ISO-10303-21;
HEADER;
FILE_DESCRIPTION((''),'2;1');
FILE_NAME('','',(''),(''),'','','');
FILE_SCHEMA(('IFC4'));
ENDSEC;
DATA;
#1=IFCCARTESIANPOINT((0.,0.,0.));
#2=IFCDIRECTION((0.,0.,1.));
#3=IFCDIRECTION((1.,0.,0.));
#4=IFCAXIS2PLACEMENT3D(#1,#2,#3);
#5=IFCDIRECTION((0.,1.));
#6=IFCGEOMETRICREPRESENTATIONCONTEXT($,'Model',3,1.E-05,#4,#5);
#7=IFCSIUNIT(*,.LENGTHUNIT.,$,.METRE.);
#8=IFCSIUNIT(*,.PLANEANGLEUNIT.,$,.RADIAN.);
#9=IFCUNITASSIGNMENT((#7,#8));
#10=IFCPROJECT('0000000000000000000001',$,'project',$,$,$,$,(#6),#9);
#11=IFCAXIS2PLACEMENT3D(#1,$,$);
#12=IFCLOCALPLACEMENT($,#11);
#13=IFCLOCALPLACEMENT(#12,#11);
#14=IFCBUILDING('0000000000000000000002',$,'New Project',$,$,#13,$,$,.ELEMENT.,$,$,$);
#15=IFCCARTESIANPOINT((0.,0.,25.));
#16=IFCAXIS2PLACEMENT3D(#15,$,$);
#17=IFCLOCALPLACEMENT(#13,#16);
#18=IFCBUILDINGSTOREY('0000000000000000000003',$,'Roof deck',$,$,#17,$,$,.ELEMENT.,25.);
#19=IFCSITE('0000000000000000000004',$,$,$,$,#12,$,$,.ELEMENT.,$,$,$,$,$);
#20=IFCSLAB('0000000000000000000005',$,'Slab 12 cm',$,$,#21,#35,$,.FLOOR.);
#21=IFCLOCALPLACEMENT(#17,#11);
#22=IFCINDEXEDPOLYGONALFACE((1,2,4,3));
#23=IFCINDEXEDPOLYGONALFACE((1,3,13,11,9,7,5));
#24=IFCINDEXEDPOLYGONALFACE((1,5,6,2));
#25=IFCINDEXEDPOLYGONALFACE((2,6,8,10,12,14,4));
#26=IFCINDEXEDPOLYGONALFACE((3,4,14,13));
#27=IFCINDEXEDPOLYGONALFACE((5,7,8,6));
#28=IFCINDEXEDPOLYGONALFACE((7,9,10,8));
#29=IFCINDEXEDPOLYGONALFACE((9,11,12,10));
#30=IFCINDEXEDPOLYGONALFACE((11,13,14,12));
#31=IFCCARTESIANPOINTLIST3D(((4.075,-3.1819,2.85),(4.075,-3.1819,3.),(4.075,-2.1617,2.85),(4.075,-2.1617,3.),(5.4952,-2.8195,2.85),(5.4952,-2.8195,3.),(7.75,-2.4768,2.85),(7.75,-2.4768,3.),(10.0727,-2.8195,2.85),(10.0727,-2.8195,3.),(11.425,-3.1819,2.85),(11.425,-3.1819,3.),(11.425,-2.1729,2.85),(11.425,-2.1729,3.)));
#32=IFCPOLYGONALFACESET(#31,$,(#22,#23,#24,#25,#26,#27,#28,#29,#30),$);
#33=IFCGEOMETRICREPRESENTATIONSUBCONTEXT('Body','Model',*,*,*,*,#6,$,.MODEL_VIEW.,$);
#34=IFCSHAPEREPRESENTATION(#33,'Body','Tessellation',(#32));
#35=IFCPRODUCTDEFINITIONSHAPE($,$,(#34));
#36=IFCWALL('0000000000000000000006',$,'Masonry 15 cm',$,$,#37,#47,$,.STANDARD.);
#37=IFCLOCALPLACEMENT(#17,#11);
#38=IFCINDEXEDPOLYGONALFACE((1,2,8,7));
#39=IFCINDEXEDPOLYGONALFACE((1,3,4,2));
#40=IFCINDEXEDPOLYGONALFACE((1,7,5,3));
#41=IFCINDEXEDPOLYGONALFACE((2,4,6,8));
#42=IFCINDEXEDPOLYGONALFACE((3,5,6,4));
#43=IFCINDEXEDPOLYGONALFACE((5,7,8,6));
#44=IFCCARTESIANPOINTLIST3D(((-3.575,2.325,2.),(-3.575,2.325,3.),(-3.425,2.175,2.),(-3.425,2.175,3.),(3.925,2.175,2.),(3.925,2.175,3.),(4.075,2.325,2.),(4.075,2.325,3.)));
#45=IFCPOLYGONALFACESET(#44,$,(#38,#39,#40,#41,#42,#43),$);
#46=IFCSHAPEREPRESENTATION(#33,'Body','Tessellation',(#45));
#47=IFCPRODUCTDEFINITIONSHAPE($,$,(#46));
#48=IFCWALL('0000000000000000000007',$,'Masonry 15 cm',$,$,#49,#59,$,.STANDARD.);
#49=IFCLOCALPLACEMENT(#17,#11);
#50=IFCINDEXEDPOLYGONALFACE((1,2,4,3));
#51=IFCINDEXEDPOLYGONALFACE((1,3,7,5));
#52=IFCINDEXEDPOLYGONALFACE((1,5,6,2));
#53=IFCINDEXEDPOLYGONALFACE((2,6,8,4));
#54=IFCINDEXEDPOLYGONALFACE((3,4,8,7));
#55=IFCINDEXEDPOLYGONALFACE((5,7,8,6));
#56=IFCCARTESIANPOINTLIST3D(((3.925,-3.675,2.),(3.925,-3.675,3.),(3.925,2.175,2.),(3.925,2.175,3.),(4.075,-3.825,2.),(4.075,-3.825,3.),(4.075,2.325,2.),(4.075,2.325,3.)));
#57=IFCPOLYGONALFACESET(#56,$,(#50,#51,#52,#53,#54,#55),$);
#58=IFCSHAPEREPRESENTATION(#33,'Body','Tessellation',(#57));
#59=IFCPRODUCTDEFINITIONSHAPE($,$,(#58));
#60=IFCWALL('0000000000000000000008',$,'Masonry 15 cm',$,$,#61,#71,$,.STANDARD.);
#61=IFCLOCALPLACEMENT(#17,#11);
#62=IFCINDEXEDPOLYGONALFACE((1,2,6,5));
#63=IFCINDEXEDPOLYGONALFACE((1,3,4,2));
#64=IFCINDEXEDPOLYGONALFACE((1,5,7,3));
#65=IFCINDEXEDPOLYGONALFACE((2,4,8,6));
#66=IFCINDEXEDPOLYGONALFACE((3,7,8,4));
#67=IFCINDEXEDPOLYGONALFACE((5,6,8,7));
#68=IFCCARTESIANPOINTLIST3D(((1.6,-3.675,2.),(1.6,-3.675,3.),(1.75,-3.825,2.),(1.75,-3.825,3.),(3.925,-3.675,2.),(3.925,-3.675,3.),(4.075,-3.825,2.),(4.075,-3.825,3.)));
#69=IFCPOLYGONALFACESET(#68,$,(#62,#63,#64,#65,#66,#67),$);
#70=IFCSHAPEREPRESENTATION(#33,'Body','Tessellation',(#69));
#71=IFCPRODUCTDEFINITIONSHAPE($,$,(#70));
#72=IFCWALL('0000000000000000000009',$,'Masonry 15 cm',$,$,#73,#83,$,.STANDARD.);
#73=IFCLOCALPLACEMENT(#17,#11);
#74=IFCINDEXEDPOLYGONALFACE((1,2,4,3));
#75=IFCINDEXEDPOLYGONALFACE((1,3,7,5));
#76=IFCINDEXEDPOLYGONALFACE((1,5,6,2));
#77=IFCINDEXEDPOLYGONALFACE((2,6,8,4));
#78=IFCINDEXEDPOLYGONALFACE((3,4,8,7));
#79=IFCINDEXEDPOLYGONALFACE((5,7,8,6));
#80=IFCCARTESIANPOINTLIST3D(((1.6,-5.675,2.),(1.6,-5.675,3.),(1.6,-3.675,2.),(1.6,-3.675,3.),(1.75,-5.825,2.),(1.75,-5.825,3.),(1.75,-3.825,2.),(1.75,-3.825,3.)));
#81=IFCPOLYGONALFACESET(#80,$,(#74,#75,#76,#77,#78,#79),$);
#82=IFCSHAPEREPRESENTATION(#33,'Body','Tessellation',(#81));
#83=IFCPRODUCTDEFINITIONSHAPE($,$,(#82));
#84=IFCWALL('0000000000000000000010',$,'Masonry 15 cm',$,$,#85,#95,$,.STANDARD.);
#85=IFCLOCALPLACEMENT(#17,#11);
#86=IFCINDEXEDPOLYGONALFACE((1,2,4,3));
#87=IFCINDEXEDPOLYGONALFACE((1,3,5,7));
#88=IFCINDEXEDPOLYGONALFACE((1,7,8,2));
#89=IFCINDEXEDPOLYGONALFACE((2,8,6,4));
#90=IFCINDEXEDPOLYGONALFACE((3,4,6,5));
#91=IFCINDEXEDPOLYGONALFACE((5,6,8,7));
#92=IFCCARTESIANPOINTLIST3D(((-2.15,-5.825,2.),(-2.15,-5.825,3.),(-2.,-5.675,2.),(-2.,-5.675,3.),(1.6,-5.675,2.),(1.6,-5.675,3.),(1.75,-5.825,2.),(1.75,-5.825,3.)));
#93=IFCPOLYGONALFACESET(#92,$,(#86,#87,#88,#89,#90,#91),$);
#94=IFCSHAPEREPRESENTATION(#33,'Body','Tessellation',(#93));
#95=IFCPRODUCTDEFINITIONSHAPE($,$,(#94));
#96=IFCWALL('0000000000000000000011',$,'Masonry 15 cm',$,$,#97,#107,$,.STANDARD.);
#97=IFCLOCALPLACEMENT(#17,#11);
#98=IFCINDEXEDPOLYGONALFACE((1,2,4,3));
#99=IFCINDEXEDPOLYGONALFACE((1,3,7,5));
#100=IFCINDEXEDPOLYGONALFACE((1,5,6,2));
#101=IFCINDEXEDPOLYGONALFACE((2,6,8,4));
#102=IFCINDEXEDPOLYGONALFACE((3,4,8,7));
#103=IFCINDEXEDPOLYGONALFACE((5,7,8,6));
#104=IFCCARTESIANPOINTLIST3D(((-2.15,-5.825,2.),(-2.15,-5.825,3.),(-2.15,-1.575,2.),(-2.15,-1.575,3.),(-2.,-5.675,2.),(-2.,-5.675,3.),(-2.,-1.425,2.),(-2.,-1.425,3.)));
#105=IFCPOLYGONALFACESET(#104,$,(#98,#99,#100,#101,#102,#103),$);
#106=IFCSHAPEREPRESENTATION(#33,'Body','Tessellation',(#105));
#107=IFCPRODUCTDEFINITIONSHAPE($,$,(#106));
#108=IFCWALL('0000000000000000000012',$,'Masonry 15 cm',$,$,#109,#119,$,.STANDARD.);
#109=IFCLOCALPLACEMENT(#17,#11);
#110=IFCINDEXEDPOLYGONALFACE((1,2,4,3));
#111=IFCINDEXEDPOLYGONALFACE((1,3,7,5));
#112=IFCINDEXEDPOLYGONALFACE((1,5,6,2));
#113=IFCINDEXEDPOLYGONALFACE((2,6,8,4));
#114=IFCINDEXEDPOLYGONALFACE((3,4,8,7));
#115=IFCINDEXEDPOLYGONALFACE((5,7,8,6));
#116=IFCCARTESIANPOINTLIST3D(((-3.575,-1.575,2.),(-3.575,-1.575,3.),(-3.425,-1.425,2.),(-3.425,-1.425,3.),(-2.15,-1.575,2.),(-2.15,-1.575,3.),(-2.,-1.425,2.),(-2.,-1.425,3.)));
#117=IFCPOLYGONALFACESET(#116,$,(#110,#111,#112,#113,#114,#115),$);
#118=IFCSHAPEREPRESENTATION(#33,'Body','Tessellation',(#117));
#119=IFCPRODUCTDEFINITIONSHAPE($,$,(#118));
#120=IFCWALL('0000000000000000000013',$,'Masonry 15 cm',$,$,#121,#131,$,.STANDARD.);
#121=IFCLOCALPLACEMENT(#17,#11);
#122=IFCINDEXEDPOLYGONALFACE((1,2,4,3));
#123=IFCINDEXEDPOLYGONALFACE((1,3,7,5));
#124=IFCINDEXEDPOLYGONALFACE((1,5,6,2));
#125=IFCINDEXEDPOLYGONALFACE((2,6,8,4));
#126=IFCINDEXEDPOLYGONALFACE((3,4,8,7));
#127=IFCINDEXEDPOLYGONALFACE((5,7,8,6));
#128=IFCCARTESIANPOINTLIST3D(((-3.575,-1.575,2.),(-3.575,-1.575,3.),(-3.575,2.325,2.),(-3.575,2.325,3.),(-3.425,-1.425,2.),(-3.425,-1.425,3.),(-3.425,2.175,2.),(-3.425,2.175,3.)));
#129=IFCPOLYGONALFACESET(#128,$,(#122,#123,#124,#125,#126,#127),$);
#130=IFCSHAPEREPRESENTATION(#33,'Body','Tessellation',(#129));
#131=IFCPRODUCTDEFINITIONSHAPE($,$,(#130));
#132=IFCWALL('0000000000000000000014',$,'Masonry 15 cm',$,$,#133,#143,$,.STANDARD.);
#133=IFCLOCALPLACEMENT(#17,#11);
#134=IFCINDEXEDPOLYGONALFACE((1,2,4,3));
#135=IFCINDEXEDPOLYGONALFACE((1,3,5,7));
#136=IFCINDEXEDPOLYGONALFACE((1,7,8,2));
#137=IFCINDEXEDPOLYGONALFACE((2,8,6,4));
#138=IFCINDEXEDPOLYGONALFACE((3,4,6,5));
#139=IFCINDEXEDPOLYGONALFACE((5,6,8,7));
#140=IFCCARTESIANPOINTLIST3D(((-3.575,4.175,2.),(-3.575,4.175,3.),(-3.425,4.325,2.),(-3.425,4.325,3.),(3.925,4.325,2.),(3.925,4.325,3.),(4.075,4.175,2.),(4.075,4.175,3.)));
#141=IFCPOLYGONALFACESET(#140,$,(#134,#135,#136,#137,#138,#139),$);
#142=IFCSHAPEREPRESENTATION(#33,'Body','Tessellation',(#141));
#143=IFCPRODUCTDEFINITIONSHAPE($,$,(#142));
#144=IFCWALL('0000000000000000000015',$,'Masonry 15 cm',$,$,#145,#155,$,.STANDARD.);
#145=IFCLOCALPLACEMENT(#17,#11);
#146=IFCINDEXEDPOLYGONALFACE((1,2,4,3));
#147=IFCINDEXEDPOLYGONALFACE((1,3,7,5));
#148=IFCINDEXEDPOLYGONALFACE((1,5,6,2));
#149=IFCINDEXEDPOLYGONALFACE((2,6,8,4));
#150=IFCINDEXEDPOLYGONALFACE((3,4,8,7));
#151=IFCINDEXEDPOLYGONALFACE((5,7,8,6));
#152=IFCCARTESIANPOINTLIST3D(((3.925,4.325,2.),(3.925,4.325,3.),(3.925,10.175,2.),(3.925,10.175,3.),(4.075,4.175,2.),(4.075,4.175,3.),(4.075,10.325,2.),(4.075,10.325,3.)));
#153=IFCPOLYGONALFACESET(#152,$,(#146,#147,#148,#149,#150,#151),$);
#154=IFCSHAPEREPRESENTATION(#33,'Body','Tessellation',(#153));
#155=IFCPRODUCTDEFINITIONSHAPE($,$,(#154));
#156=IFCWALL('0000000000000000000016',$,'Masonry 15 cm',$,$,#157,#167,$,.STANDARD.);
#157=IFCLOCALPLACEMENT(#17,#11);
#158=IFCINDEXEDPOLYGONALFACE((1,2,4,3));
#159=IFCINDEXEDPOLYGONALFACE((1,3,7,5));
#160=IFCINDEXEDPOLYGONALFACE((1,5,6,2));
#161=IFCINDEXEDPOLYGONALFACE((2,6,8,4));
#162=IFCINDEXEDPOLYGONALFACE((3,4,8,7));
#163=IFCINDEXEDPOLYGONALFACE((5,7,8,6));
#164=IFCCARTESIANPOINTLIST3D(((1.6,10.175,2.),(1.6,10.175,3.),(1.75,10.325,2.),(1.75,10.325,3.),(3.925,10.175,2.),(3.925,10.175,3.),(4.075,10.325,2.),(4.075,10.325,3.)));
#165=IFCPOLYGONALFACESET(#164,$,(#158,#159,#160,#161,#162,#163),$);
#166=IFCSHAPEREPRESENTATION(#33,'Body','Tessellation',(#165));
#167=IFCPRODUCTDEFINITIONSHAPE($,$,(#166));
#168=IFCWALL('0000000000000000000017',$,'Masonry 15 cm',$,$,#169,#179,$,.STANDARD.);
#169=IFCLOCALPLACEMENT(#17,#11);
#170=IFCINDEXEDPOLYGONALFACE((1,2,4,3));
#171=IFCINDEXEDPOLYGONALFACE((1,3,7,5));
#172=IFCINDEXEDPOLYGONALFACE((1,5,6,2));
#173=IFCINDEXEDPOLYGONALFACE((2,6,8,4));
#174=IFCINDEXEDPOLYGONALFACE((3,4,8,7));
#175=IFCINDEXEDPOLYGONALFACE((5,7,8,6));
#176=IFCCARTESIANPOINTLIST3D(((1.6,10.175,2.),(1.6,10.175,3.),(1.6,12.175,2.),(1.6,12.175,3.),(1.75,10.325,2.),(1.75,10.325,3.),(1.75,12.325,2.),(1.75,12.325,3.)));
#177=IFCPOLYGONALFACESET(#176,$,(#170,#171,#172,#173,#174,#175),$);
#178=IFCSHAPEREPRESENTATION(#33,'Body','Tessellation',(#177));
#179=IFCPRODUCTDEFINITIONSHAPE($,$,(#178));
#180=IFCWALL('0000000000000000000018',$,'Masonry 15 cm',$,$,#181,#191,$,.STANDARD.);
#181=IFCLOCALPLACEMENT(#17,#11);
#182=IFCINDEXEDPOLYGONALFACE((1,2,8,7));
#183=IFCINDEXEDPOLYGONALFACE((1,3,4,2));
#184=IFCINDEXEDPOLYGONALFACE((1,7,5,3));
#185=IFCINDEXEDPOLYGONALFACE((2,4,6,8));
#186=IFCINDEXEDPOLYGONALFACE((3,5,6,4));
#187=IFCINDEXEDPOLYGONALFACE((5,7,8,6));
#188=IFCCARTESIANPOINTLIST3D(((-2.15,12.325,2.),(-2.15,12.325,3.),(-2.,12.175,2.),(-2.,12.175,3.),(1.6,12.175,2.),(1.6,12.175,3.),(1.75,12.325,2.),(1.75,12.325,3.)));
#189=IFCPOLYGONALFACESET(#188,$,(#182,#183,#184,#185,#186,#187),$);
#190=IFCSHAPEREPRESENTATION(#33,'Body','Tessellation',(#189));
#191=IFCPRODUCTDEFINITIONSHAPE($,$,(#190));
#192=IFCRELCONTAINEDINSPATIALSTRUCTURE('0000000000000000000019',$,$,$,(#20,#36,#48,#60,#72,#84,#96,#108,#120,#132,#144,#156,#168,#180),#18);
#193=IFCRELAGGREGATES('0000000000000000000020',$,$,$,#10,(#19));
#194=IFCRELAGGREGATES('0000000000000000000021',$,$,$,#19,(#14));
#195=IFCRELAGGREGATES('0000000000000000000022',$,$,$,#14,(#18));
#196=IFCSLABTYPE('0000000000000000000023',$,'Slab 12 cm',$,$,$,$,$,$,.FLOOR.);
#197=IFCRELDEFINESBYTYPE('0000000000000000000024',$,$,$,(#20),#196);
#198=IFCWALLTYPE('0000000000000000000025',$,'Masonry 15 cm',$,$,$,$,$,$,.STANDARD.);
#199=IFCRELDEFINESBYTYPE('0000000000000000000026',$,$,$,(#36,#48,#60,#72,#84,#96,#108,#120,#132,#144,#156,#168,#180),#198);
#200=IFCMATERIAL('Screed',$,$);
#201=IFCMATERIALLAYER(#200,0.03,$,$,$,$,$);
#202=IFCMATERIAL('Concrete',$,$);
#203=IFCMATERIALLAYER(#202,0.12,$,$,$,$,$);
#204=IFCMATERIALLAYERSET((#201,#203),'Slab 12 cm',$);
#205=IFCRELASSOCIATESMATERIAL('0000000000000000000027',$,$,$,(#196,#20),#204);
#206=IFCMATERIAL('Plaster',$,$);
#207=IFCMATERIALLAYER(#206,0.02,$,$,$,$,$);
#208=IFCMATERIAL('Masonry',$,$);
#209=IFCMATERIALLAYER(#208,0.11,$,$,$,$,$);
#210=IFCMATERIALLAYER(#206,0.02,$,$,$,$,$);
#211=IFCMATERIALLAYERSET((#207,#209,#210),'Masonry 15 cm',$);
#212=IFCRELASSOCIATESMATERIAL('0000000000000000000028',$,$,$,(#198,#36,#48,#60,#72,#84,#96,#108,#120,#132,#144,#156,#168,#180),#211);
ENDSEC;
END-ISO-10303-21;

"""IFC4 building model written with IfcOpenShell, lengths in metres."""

from ifc_helpers import new_model, si_unit, direction, frame, origin, origin_with_axes, place, context, subcontext, project, spatial, polyline, outline, extrude, material, layer, layer_set, layer_usage, type_object, element, save


model = new_model("IFC4")

# Units and contexts
model_context = context("Model", 3, precision=1e-05, world=origin_with_axes(), true_north=direction((0.0, 1.0)))
body_context = subcontext(model_context, "Body", "Model", "MODEL_VIEW")
ifc_project = project(units=[si_unit("LENGTHUNIT", "METRE"), si_unit("PLANEANGLEUNIT", "RADIAN")], contexts=[model_context])

# Site, building, storey
site_placement = place(None, origin())
site = spatial("IfcSite", under=ifc_project, at=site_placement, CompositionType="ELEMENT")
building_placement = place(site_placement, origin())
building = spatial("IfcBuilding", under=site, at=building_placement, Name="New Project", CompositionType="ELEMENT")
storey_placement = place(building_placement, frame((0.0, 0.0, 25.0)))
storey = spatial("IfcBuildingStorey", under=building, at=storey_placement, Name="Roof deck", CompositionType="ELEMENT", Elevation=25.0)

# Slab
ifc_material_1 = material(Name="Screed")
ifc_layer_1 = layer(ifc_material_1, 0.03)
ifc_material_2 = material(Name="Concrete")
ifc_layer_2 = layer(ifc_material_2, 0.12)
ifc_layer_set_1 = layer_set([ifc_layer_1, ifc_layer_2], Name="Slab 12 cm")
ifc_layer_usage_1 = layer_usage(ifc_layer_set_1, "AXIS3", "NEGATIVE", 0.15)
slab_type = type_object("IfcSlabType", Name="Slab 12 cm", PredefinedType="FLOOR", material=ifc_layer_set_1)
slab_placement = place(storey_placement, frame((0.0, 0.0, 2.85)))
element("IfcSlab", 1, at=slab_placement, inside=storey, type_object=slab_type, material=ifc_layer_usage_1, Name="Slab 12 cm", PredefinedType="FLOOR", context=body_context, shape_type="SweptSolid", body=[
    extrude(outline(polyline([(4.075, -3.1819), (5.4952, -2.8195), (7.75, -2.4768), (10.0727, -2.8195), (11.425, -3.1819), (11.425, -2.1729), (4.075, -2.1617), (4.075, -3.1819)])), origin(), (0.0, 0.0, 1.0), 0.15),
])

# Walls
ifc_material_3 = material(Name="Plaster")
ifc_layer_3 = layer(ifc_material_3, 0.02)
ifc_material_4 = material(Name="Masonry")
ifc_layer_4 = layer(ifc_material_4, 0.11)
ifc_layer_5 = layer(ifc_material_3, 0.02)
ifc_layer_set_2 = layer_set([ifc_layer_3, ifc_layer_4, ifc_layer_5], Name="Masonry 15 cm")
ifc_layer_usage_2 = layer_usage(ifc_layer_set_2, "AXIS2", "NEGATIVE", 0.075)
wall_type_1 = type_object("IfcWallType", Name="Masonry 15 cm", PredefinedType="STANDARD", material=ifc_layer_set_2)
wall_1_placement = place(storey_placement, frame((-3.5, 2.25, 2.0)))
element("IfcWall", 2, at=wall_1_placement, inside=storey, type_object=wall_type_1, material=ifc_layer_usage_2, Name="Masonry 15 cm", PredefinedType="STANDARD", context=body_context, shape_type="SweptSolid", body=[
    extrude(outline(polyline([(0.075, -0.075), (7.425, -0.075), (7.575, 0.075), (-0.075, 0.075), (0.075, -0.075)])), origin(), (0.0, 0.0, 1.0), 1.0),
])
wall_2_placement = place(storey_placement, frame((4.0, 2.25, 2.0), z_axis=(0.0, 0.0, 1.0), x_axis=(0.0, -1.0, 0.0)))
element("IfcWall", 3, at=wall_2_placement, inside=storey, type_object=wall_type_1, material=ifc_layer_usage_2, Name="Masonry 15 cm", PredefinedType="STANDARD", context=body_context, shape_type="SweptSolid", body=[
    extrude(outline(polyline([(0.075, -0.075), (5.925, -0.075), (6.075, 0.075), (-0.075, 0.075), (0.075, -0.075)])), origin(), (0.0, 0.0, 1.0), 1.0),
])
wall_3_placement = place(storey_placement, frame((4.0, -3.75, 2.0), z_axis=(0.0, 0.0, 1.0), x_axis=(-1.0, 0.0, 0.0)))
element("IfcWall", 4, at=wall_3_placement, inside=storey, type_object=wall_type_1, material=ifc_layer_usage_2, Name="Masonry 15 cm", PredefinedType="STANDARD", context=body_context, shape_type="SweptSolid", body=[
    extrude(outline(polyline([(0.075, -0.075), (2.4, -0.075), (2.25, 0.075), (-0.075, 0.075), (0.075, -0.075)])), origin(), (0.0, 0.0, 1.0), 1.0),
])
wall_4_placement = place(storey_placement, frame((1.675, -3.75, 2.0), z_axis=(0.0, 0.0, 1.0), x_axis=(0.0, -1.0, 0.0)))
element("IfcWall", 5, at=wall_4_placement, inside=storey, type_object=wall_type_1, material=ifc_layer_usage_2, Name="Masonry 15 cm", PredefinedType="STANDARD", context=body_context, shape_type="SweptSolid", body=[
    extrude(outline(polyline([(-0.075, -0.075), (1.925, -0.075), (2.075, 0.075), (0.075, 0.075), (-0.075, -0.075)])), origin(), (0.0, 0.0, 1.0), 1.0),
])
wall_5_placement = place(storey_placement, frame((1.675, -5.75, 2.0), z_axis=(0.0, 0.0, 1.0), x_axis=(-1.0, 0.0, 0.0)))
element("IfcWall", 6, at=wall_5_placement, inside=storey, type_object=wall_type_1, material=ifc_layer_usage_2, Name="Masonry 15 cm", PredefinedType="STANDARD", context=body_context, shape_type="SweptSolid", body=[
    extrude(outline(polyline([(0.075, -0.075), (3.675, -0.075), (3.825, 0.075), (-0.075, 0.075), (0.075, -0.075)])), origin(), (0.0, 0.0, 1.0), 1.0),
])
wall_6_placement = place(storey_placement, frame((-2.075, -5.75, 2.0), z_axis=(0.0, 0.0, 1.0), x_axis=(0.0, 1.0, 0.0)))
element("IfcWall", 7, at=wall_6_placement, inside=storey, type_object=wall_type_1, material=ifc_layer_usage_2, Name="Masonry 15 cm", PredefinedType="STANDARD", context=body_context, shape_type="SweptSolid", body=[
    extrude(outline(polyline([(0.075, -0.075), (4.325, -0.075), (4.175, 0.075), (-0.075, 0.075), (0.075, -0.075)])), origin(), (0.0, 0.0, 1.0), 1.0),
])
wall_7_placement = place(storey_placement, frame((-2.075, -1.5, 2.0), z_axis=(0.0, 0.0, 1.0), x_axis=(-1.0, 0.0, 0.0)))
element("IfcWall", 8, at=wall_7_placement, inside=storey, type_object=wall_type_1, material=ifc_layer_usage_2, Name="Masonry 15 cm", PredefinedType="STANDARD", context=body_context, shape_type="SweptSolid", body=[
    extrude(outline(polyline([(-0.075, -0.075), (1.35, -0.075), (1.5, 0.075), (0.075, 0.075), (-0.075, -0.075)])), origin(), (0.0, 0.0, 1.0), 1.0),
])
wall_8_placement = place(storey_placement, frame((-3.5, -1.5, 2.0), z_axis=(0.0, 0.0, 1.0), x_axis=(0.0, 1.0, 0.0)))
element("IfcWall", 9, at=wall_8_placement, inside=storey, type_object=wall_type_1, material=ifc_layer_usage_2, Name="Masonry 15 cm", PredefinedType="STANDARD", context=body_context, shape_type="SweptSolid", body=[
    extrude(outline(polyline([(0.075, -0.075), (3.675, -0.075), (3.825, 0.075), (-0.075, 0.075), (0.075, -0.075)])), origin(), (0.0, 0.0, 1.0), 1.0),
])
wall_9_placement = place(storey_placement, frame((4.0, 4.25, 2.0), z_axis=(0.0, 0.0, 1.0), x_axis=(-1.0, 0.0, 0.0)))
element("IfcWall", 10, at=wall_9_placement, inside=storey, type_object=wall_type_1, material=ifc_layer_usage_2, Name="Masonry 15 cm", PredefinedType="STANDARD", context=body_context, shape_type="SweptSolid", body=[
    extrude(outline(polyline([(0.075, -0.075), (7.425, -0.075), (7.575, 0.075), (-0.075, 0.075), (0.075, -0.075)])), origin(), (0.0, 0.0, 1.0), 1.0),
])
wall_10_placement = place(storey_placement, frame((4.0, 10.25, 2.0), z_axis=(0.0, 0.0, 1.0), x_axis=(0.0, -1.0, 0.0)))
element("IfcWall", 11, at=wall_10_placement, inside=storey, type_object=wall_type_1, material=ifc_layer_usage_2, Name="Masonry 15 cm", PredefinedType="STANDARD", context=body_context, shape_type="SweptSolid", body=[
    extrude(outline(polyline([(0.075, -0.075), (5.925, -0.075), (6.075, 0.075), (-0.075, 0.075), (0.075, -0.075)])), origin(), (0.0, 0.0, 1.0), 1.0),
])
wall_11_placement = place(storey_placement, frame((1.675, 10.25, 2.0)))
element("IfcWall", 12, at=wall_11_placement, inside=storey, type_object=wall_type_1, material=ifc_layer_usage_2, Name="Masonry 15 cm", PredefinedType="STANDARD", context=body_context, shape_type="SweptSolid", body=[
    extrude(outline(polyline([(-0.075, -0.075), (2.25, -0.075), (2.4, 0.075), (0.075, 0.075), (-0.075, -0.075)])), origin(), (0.0, 0.0, 1.0), 1.0),
])
wall_12_placement = place(storey_placement, frame((1.675, 12.25, 2.0), z_axis=(0.0, 0.0, 1.0), x_axis=(0.0, -1.0, 0.0)))
element("IfcWall", 13, at=wall_12_placement, inside=storey, type_object=wall_type_1, material=ifc_layer_usage_2, Name="Masonry 15 cm", PredefinedType="STANDARD", context=body_context, shape_type="SweptSolid", body=[
    extrude(outline(polyline([(0.075, -0.075), (2.075, -0.075), (1.925, 0.075), (-0.075, 0.075), (0.075, -0.075)])), origin(), (0.0, 0.0, 1.0), 1.0),
])
wall_13_placement = place(storey_placement, frame((-2.075, 12.25, 2.0)))
element("IfcWall", 14, at=wall_13_placement, inside=storey, type_object=wall_type_1, material=ifc_layer_usage_2, Name="Masonry 15 cm", PredefinedType="STANDARD", context=body_context, shape_type="SweptSolid", body=[
    extrude(outline(polyline([(0.075, -0.075), (3.675, -0.075), (3.825, 0.075), (-0.075, 0.075), (0.075, -0.075)])), origin(), (0.0, 0.0, 1.0), 1.0),
])

save(model, "model.ifc")
